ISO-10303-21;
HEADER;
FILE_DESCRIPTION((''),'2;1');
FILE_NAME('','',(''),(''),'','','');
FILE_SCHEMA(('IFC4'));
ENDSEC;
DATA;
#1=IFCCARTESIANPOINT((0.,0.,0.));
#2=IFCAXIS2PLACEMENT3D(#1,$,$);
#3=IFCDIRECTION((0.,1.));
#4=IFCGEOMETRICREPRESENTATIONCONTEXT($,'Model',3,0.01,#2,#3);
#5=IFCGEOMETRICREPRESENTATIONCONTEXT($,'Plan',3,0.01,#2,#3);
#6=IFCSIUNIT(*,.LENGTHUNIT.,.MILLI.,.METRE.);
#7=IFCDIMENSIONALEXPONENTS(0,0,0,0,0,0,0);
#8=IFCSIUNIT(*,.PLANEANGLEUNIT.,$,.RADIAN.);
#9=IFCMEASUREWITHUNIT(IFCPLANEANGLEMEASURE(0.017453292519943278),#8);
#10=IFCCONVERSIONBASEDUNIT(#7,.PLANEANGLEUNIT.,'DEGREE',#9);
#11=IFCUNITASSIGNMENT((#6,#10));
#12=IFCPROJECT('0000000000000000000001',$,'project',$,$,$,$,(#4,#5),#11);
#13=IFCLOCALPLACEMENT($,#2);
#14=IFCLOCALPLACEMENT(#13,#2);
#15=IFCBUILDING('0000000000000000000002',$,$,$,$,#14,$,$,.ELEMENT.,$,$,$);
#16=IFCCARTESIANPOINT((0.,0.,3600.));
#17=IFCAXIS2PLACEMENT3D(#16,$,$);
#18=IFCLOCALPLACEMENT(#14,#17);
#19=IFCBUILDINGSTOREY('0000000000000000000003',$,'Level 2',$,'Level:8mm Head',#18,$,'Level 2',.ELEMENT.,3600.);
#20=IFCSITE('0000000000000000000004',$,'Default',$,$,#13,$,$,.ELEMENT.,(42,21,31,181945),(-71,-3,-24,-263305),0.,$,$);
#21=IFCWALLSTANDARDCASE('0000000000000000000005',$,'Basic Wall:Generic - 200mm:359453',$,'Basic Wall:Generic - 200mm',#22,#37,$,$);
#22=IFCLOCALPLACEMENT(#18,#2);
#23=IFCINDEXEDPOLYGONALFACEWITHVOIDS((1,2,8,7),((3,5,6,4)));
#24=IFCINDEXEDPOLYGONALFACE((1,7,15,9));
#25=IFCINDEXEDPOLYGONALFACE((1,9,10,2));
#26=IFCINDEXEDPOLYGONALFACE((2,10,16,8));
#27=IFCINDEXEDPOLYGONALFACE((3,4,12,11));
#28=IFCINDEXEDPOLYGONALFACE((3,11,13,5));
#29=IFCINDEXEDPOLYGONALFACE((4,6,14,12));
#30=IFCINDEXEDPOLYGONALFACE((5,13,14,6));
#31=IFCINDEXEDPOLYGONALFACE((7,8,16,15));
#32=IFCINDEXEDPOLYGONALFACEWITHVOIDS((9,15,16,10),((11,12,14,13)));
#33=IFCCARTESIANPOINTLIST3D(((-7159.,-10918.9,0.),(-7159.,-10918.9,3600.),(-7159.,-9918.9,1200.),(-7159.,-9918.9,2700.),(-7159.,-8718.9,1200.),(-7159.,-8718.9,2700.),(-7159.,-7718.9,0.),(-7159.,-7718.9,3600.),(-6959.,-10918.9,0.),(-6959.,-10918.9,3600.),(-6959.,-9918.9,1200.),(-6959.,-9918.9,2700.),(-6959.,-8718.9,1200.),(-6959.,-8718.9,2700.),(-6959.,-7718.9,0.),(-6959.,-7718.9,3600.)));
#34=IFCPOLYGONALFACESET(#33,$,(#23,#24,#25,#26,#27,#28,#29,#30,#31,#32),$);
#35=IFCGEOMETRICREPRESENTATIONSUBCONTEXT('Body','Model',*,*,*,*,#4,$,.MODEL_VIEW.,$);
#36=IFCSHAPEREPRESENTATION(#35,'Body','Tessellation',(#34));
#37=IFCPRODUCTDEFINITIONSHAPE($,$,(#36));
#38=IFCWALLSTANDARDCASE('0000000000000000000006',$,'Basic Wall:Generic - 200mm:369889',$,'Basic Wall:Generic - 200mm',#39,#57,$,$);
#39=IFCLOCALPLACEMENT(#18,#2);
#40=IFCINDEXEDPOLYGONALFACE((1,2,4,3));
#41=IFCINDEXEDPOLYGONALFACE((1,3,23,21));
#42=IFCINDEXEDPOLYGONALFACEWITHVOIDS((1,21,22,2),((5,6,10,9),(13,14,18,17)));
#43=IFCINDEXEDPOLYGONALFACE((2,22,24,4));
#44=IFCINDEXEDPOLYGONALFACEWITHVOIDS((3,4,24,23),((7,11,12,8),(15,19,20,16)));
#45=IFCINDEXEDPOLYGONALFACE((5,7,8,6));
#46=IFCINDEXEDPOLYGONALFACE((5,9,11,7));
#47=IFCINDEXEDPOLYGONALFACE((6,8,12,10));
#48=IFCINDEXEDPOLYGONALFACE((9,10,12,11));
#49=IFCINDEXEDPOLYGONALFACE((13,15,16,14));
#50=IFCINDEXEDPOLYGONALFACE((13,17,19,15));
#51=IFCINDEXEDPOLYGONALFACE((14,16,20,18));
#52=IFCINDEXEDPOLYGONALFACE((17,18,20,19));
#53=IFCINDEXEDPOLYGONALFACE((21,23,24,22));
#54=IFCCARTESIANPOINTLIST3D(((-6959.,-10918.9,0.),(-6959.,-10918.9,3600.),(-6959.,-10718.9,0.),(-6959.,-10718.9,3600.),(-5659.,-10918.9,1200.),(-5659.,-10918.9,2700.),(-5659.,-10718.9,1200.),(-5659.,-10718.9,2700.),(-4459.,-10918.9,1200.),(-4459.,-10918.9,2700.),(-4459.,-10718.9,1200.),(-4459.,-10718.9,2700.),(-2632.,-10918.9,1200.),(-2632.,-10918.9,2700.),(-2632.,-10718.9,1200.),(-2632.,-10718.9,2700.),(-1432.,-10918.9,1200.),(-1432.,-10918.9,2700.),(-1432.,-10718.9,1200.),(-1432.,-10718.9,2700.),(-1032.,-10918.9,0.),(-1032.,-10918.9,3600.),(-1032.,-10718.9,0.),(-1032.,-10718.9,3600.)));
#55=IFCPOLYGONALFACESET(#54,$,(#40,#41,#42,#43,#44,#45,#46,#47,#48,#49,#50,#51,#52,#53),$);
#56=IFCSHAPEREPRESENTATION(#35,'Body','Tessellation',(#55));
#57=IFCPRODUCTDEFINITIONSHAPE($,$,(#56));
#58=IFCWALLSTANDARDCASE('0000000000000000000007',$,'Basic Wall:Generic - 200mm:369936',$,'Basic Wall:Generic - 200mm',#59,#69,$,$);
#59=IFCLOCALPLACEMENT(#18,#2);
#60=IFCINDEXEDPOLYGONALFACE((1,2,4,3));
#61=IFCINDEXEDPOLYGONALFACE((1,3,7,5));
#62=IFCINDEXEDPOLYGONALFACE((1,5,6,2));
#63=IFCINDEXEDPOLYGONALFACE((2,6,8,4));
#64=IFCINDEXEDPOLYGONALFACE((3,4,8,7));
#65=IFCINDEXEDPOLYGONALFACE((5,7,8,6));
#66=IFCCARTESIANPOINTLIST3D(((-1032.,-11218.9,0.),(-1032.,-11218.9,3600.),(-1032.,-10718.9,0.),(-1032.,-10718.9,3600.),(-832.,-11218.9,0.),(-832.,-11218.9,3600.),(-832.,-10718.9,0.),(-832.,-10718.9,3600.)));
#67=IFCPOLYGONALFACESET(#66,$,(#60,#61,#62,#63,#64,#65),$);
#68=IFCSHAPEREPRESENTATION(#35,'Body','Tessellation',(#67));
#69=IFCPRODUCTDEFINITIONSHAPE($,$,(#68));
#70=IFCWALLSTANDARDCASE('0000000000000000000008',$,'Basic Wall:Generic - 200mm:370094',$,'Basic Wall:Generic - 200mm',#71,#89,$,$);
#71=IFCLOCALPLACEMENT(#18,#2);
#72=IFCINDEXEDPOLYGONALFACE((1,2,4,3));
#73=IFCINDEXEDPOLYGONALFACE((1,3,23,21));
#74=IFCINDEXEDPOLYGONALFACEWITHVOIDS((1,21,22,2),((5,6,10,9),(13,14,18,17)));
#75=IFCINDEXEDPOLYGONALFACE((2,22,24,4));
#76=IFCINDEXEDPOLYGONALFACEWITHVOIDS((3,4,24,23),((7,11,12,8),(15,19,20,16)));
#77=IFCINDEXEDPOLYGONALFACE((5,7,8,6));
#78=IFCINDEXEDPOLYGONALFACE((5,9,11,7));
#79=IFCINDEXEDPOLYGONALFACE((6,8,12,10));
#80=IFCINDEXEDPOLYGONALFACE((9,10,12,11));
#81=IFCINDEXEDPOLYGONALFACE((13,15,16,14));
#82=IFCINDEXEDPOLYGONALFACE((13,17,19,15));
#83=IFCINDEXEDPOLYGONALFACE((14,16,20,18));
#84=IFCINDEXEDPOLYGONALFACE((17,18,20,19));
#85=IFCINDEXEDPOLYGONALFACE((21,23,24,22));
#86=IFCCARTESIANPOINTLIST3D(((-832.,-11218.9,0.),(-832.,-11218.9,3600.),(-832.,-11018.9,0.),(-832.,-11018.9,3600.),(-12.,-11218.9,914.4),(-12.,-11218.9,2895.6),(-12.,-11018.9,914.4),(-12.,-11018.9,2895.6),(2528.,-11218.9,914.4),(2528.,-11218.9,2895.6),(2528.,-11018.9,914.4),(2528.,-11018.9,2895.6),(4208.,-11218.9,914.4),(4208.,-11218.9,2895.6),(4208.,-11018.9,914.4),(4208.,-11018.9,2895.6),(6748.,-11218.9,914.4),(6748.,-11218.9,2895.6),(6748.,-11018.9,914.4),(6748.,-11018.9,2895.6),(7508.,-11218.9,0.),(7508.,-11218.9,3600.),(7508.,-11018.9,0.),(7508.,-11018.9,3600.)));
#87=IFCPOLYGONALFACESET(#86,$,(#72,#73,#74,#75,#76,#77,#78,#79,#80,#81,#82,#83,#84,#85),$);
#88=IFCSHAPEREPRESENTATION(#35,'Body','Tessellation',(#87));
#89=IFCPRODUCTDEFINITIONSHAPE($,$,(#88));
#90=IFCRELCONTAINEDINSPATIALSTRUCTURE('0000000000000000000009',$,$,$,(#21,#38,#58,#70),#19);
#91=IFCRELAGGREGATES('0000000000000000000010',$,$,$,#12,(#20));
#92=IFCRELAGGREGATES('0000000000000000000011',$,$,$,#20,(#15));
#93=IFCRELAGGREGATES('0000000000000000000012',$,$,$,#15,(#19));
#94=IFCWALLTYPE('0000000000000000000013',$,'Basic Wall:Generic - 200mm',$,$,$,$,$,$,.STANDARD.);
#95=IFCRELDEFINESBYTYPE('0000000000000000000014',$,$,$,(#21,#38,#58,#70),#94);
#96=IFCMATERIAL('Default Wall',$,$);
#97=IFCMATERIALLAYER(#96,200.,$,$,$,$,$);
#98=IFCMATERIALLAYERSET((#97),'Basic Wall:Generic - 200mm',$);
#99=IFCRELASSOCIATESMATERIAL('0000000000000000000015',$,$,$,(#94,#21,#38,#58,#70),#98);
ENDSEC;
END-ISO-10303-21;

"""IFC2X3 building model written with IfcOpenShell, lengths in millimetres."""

from ifc_helpers import new_model, entity, si_unit, converted_unit, direction, frame, frame_2d, origin, place, context, subcontext, project, spatial, rectangle, extrude, material, layer, layer_set, layer_usage, type_object, element, save


model = new_model("IFC2X3")

# Units and contexts
model_context = context("Model", 3, precision=0.01, world=origin(), true_north=direction((0.0, 1.0)))
plan_context = context("Plan", 3, precision=0.01, world=origin(), true_north=direction((0.0, 1.0)))
body_context = subcontext(model_context, "Body", "Model", "MODEL_VIEW")
ifc_project = project(units=[si_unit("LENGTHUNIT", "METRE", prefix="MILLI"), converted_unit("PLANEANGLEUNIT", "DEGREE", entity("IfcPlaneAngleMeasure", 0.017453292519943278), si_unit("PLANEANGLEUNIT", "RADIAN"), dimensions=[0, 0, 0, 0, 0, 0, 0])], contexts=[model_context, plan_context])

# Site, building, storey
site_placement = place(None, origin())
site = spatial("IfcSite", under=ifc_project, at=site_placement, Name="Default", CompositionType="ELEMENT", RefLatitude=(42, 21, 31, 181945), RefLongitude=(-71, -3, -24, -263305), RefElevation=0.0)
building_placement = place(site_placement, origin())
building = spatial("IfcBuilding", under=site, at=building_placement, CompositionType="ELEMENT")
storey_placement = place(building_placement, frame((0.0, 0.0, 3600.0)))
storey = spatial("IfcBuildingStorey", under=building, at=storey_placement, Name="Level 2", ObjectType="Level:8mm Head", LongName="Level 2", CompositionType="ELEMENT", Elevation=3600.0)

# Wall, opening
ifc_material_1 = material(Name="Default Wall")
ifc_layer = layer(ifc_material_1, 200.0)
ifc_layer_set = layer_set([ifc_layer], Name="Basic Wall:Generic - 200mm")
ifc_layer_usage_1 = layer_usage(ifc_layer_set, "AXIS2", "NEGATIVE", 100.0)
wall_type = type_object("IfcWallType", Name="Basic Wall:Generic - 200mm", PredefinedType="STANDARD", material=ifc_layer_set)
wall_1_placement = place(storey_placement, frame((-7059.0, -10918.9, 0.0), z_axis=(0.0, 0.0, 1.0), x_axis=(0.0, 1.0, 0.0)))
wall_1 = element("IfcWallStandardCase", 1, at=wall_1_placement, inside=storey, type_object=wall_type, material=ifc_layer_usage_1, Name="Basic Wall:Generic - 200mm:359453", ObjectType="Basic Wall:Generic - 200mm", context=body_context, shape_type="SweptSolid", body=[
    extrude(rectangle(XDim=3200.0, YDim=200.0, at=frame_2d((1600.0, 0.0), x_axis=(-1.0, 0.0))), origin(), (0.0, 0.0, 1.0), 3600.0),
])
opening_1_placement = place(wall_1_placement, frame((1000.0, -100.0, 1200.0)))
element("IfcOpeningElement", 2, at=opening_1_placement, cuts=wall_1, ObjectType="Opening", context=body_context, shape_type="SweptSolid", body=[
    extrude(rectangle(XDim=1500.0, YDim=1200.0, at=frame_2d((750.0, 600.0), x_axis=(-1.0, 0.0))), frame((0.0, 0.0, 0.0), z_axis=(0.0, 1.0, 0.0), x_axis=(0.0, 0.0, 1.0)), (0.0, 0.0, 1.0), 200.0),
])

# Wall, openings
ifc_layer_usage_2 = layer_usage(ifc_layer_set, "AXIS2", "NEGATIVE", 100.0)
wall_2_placement = place(storey_placement, frame((-6959.0, -10818.9, 0.0)))
wall_2 = element("IfcWallStandardCase", 3, at=wall_2_placement, inside=storey, type_object=wall_type, material=ifc_layer_usage_2, Name="Basic Wall:Generic - 200mm:369889", ObjectType="Basic Wall:Generic - 200mm", context=body_context, shape_type="SweptSolid", body=[
    extrude(rectangle(XDim=5927.0, YDim=200.0, at=frame_2d((2963.5, 0.0), x_axis=(-1.0, 0.0))), origin(), (0.0, 0.0, 1.0), 3600.0),
])
opening_2_placement = place(wall_2_placement, frame((2500.0, 100.0, 1200.0)))
element("IfcOpeningElement", 4, at=opening_2_placement, cuts=wall_2, ObjectType="Opening", context=body_context, shape_type="SweptSolid", body=[
    extrude(rectangle(XDim=1500.0, YDim=1200.0, at=frame_2d((750.0, 600.0), x_axis=(-1.0, 0.0))), frame((0.0, 0.0, 0.0), z_axis=(0.0, -1.0, 0.0), x_axis=(0.0, 0.0, 1.0)), (0.0, 0.0, 1.0), 200.0),
])
opening_3_placement = place(wall_2_placement, frame((5527.0, 100.0, 1200.0)))
element("IfcOpeningElement", 5, at=opening_3_placement, cuts=wall_2, ObjectType="Opening", context=body_context, shape_type="SweptSolid", body=[
    extrude(rectangle(XDim=1500.0, YDim=1200.0, at=frame_2d((750.0, 600.0), x_axis=(-1.0, 0.0))), frame((0.0, 0.0, 0.0), z_axis=(0.0, -1.0, 0.0), x_axis=(0.0, 0.0, 1.0)), (0.0, 0.0, 1.0), 200.0),
])

# Wall
ifc_layer_usage_3 = layer_usage(ifc_layer_set, "AXIS2", "NEGATIVE", 100.0)
wall_3_placement = place(storey_placement, frame((-932.0, -10718.9, 0.0), z_axis=(0.0, 0.0, 1.0), x_axis=(0.0, -1.0, 0.0)))
element("IfcWallStandardCase", 6, at=wall_3_placement, inside=storey, type_object=wall_type, material=ifc_layer_usage_3, Name="Basic Wall:Generic - 200mm:369936", ObjectType="Basic Wall:Generic - 200mm", context=body_context, shape_type="SweptSolid", body=[
    extrude(rectangle(XDim=500.0, YDim=200.0, at=frame_2d((250.0, 0.0), x_axis=(-1.0, 0.0))), origin(), (0.0, 0.0, 1.0), 3600.0),
])

# Wall, openings
ifc_layer_usage_4 = layer_usage(ifc_layer_set, "AXIS2", "NEGATIVE", 100.0)
wall_4_placement = place(storey_placement, frame((-832.0, -11118.9, 0.0)))
wall_4 = element("IfcWallStandardCase", 7, at=wall_4_placement, inside=storey, type_object=wall_type, material=ifc_layer_usage_4, Name="Basic Wall:Generic - 200mm:370094", ObjectType="Basic Wall:Generic - 200mm", context=body_context, shape_type="SweptSolid", body=[
    extrude(rectangle(XDim=8340.0, YDim=200.0, at=frame_2d((4170.0, 0.0), x_axis=(-1.0, 0.0))), origin(), (0.0, 0.0, 1.0), 3600.0),
])
opening_4_placement = place(wall_4_placement, frame((3360.0, 100.0, 914.4)))
element("IfcOpeningElement", 8, at=opening_4_placement, cuts=wall_4, ObjectType="Opening", context=body_context, shape_type="SweptSolid", body=[
    extrude(rectangle(XDim=1981.2, YDim=2540.0, at=frame_2d((990.6, 1270.0), x_axis=(-1.0, 0.0))), frame((0.0, 0.0, 0.0), z_axis=(0.0, -1.0, 0.0), x_axis=(0.0, 0.0, 1.0)), (0.0, 0.0, 1.0), 200.0),
])
opening_5_placement = place(wall_4_placement, frame((7580.0, 100.0, 914.4)))
element("IfcOpeningElement", 9, at=opening_5_placement, cuts=wall_4, ObjectType="Opening", context=body_context, shape_type="SweptSolid", body=[
    extrude(rectangle(XDim=1981.2, YDim=2540.0, at=frame_2d((990.6, 1270.0), x_axis=(-1.0, 0.0))), frame((0.0, 0.0, 0.0), z_axis=(0.0, -1.0, 0.0), x_axis=(0.0, 0.0, 1.0)), (0.0, 0.0, 1.0), 200.0),
])

save(model, "model.ifc")
